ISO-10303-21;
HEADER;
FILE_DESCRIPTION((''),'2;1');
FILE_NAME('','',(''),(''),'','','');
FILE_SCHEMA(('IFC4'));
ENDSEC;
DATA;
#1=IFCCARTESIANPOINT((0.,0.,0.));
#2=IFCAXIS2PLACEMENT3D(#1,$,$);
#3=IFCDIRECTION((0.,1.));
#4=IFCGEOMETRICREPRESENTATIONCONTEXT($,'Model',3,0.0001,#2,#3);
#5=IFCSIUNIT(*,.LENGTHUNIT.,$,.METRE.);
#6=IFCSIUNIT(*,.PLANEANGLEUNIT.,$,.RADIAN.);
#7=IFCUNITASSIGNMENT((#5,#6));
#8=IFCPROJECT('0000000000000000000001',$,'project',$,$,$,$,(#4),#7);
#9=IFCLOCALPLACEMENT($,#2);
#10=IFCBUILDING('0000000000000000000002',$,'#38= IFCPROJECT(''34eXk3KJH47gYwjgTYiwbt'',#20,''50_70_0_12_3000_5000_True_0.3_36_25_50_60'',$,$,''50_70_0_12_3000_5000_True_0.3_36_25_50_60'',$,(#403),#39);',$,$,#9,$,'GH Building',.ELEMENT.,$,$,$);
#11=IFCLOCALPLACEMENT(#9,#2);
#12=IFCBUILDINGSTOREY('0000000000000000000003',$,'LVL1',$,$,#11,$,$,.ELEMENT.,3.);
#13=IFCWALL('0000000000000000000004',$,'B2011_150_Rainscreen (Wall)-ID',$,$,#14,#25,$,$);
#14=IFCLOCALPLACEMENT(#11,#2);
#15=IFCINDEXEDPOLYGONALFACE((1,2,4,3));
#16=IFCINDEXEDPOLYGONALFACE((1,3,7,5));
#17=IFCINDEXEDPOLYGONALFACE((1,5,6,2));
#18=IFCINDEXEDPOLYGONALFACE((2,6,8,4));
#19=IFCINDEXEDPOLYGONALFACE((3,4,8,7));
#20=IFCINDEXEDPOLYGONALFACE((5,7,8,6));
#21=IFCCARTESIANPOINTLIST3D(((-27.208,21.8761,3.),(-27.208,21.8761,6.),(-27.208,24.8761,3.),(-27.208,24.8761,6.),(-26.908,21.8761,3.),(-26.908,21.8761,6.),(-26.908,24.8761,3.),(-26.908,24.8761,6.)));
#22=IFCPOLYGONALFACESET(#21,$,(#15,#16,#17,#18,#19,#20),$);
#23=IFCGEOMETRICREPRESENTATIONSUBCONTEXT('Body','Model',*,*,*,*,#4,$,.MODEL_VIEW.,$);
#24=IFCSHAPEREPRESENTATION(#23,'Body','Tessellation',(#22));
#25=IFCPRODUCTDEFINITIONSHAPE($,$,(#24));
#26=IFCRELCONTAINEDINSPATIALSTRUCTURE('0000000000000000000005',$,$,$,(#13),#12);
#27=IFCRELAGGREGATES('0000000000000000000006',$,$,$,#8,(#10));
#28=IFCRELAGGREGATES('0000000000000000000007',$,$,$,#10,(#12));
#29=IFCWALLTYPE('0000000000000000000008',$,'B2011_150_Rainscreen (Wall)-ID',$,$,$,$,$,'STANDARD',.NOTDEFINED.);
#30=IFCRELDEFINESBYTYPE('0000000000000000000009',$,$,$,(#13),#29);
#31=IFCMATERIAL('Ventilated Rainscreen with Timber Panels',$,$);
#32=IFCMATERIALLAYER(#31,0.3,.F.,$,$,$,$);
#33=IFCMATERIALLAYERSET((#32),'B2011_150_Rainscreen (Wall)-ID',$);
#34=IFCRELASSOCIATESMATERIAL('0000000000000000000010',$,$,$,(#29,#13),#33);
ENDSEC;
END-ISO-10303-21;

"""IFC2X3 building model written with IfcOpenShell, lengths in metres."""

from ifc_helpers import new_model, si_unit, direction, frame, frame_2d, origin, place, context, subcontext, project, spatial, rectangle, extrude, material, layer, layer_set, layer_usage, type_object, element, save


model = new_model("IFC2X3")

# Units and contexts
model_context = context("Model", 3, precision=0.0001, world=origin(), true_north=direction((0.0, 1.0)))
body_context = subcontext(model_context, "Body", "Model", "MODEL_VIEW")
ifc_project = project(units=[si_unit("LENGTHUNIT", "METRE"), si_unit("PLANEANGLEUNIT", "RADIAN")], contexts=[model_context])

# Building, storey
building_placement = place(None, origin())
building = spatial("IfcBuilding", under=ifc_project, at=building_placement, Name="#38= IFCPROJECT('34eXk3KJH47gYwjgTYiwbt',#20,'50_70_0_12_3000_5000_True_0.3_36_25_50_60',$,$,'50_70_0_12_3000_5000_True_0.3_36_25_50_60',$,(#403),#39);", LongName="GH Building", CompositionType="ELEMENT")
storey_placement = place(building_placement, origin())
storey = spatial("IfcBuildingStorey", under=building, at=storey_placement, Name="LVL1", CompositionType="ELEMENT", Elevation=3.0)

# Wall
ifc_material_1 = material(Name="Ventilated Rainscreen with Timber Panels")
ifc_layer_1 = layer(ifc_material_1, 0.3, ventilated=False)
ifc_layer_set_1 = layer_set([ifc_layer_1], Name="B2011_150_Rainscreen (Wall)-ID")
ifc_layer_usage_1 = layer_usage(ifc_layer_set_1, "AXIS2", "POSITIVE", 0.0)
wall_type_1 = type_object("IfcWallType", Name="B2011_150_Rainscreen (Wall)-ID", ElementType="STANDARD", PredefinedType="NOTDEFINED", material=ifc_layer_set_1)
wall_1_placement = place(storey_placement, frame((-27.208, 24.8761, 3.0), z_axis=(0.0, 0.0, 1.0), x_axis=(0.0, -1.0, 0.0)))
element("IfcWall", 1, at=wall_1_placement, inside=storey, type_object=wall_type_1, material=ifc_layer_usage_1, Name="B2011_150_Rainscreen (Wall)-ID", context=body_context, shape_type="SweptSolid", body=[
    extrude(rectangle(XDim=3.0, YDim=0.3, at=frame_2d((1.5, 0.15))), origin(), (0.0, 0.0, 1.0), 3.0),
])

save(model, "model.ifc")
